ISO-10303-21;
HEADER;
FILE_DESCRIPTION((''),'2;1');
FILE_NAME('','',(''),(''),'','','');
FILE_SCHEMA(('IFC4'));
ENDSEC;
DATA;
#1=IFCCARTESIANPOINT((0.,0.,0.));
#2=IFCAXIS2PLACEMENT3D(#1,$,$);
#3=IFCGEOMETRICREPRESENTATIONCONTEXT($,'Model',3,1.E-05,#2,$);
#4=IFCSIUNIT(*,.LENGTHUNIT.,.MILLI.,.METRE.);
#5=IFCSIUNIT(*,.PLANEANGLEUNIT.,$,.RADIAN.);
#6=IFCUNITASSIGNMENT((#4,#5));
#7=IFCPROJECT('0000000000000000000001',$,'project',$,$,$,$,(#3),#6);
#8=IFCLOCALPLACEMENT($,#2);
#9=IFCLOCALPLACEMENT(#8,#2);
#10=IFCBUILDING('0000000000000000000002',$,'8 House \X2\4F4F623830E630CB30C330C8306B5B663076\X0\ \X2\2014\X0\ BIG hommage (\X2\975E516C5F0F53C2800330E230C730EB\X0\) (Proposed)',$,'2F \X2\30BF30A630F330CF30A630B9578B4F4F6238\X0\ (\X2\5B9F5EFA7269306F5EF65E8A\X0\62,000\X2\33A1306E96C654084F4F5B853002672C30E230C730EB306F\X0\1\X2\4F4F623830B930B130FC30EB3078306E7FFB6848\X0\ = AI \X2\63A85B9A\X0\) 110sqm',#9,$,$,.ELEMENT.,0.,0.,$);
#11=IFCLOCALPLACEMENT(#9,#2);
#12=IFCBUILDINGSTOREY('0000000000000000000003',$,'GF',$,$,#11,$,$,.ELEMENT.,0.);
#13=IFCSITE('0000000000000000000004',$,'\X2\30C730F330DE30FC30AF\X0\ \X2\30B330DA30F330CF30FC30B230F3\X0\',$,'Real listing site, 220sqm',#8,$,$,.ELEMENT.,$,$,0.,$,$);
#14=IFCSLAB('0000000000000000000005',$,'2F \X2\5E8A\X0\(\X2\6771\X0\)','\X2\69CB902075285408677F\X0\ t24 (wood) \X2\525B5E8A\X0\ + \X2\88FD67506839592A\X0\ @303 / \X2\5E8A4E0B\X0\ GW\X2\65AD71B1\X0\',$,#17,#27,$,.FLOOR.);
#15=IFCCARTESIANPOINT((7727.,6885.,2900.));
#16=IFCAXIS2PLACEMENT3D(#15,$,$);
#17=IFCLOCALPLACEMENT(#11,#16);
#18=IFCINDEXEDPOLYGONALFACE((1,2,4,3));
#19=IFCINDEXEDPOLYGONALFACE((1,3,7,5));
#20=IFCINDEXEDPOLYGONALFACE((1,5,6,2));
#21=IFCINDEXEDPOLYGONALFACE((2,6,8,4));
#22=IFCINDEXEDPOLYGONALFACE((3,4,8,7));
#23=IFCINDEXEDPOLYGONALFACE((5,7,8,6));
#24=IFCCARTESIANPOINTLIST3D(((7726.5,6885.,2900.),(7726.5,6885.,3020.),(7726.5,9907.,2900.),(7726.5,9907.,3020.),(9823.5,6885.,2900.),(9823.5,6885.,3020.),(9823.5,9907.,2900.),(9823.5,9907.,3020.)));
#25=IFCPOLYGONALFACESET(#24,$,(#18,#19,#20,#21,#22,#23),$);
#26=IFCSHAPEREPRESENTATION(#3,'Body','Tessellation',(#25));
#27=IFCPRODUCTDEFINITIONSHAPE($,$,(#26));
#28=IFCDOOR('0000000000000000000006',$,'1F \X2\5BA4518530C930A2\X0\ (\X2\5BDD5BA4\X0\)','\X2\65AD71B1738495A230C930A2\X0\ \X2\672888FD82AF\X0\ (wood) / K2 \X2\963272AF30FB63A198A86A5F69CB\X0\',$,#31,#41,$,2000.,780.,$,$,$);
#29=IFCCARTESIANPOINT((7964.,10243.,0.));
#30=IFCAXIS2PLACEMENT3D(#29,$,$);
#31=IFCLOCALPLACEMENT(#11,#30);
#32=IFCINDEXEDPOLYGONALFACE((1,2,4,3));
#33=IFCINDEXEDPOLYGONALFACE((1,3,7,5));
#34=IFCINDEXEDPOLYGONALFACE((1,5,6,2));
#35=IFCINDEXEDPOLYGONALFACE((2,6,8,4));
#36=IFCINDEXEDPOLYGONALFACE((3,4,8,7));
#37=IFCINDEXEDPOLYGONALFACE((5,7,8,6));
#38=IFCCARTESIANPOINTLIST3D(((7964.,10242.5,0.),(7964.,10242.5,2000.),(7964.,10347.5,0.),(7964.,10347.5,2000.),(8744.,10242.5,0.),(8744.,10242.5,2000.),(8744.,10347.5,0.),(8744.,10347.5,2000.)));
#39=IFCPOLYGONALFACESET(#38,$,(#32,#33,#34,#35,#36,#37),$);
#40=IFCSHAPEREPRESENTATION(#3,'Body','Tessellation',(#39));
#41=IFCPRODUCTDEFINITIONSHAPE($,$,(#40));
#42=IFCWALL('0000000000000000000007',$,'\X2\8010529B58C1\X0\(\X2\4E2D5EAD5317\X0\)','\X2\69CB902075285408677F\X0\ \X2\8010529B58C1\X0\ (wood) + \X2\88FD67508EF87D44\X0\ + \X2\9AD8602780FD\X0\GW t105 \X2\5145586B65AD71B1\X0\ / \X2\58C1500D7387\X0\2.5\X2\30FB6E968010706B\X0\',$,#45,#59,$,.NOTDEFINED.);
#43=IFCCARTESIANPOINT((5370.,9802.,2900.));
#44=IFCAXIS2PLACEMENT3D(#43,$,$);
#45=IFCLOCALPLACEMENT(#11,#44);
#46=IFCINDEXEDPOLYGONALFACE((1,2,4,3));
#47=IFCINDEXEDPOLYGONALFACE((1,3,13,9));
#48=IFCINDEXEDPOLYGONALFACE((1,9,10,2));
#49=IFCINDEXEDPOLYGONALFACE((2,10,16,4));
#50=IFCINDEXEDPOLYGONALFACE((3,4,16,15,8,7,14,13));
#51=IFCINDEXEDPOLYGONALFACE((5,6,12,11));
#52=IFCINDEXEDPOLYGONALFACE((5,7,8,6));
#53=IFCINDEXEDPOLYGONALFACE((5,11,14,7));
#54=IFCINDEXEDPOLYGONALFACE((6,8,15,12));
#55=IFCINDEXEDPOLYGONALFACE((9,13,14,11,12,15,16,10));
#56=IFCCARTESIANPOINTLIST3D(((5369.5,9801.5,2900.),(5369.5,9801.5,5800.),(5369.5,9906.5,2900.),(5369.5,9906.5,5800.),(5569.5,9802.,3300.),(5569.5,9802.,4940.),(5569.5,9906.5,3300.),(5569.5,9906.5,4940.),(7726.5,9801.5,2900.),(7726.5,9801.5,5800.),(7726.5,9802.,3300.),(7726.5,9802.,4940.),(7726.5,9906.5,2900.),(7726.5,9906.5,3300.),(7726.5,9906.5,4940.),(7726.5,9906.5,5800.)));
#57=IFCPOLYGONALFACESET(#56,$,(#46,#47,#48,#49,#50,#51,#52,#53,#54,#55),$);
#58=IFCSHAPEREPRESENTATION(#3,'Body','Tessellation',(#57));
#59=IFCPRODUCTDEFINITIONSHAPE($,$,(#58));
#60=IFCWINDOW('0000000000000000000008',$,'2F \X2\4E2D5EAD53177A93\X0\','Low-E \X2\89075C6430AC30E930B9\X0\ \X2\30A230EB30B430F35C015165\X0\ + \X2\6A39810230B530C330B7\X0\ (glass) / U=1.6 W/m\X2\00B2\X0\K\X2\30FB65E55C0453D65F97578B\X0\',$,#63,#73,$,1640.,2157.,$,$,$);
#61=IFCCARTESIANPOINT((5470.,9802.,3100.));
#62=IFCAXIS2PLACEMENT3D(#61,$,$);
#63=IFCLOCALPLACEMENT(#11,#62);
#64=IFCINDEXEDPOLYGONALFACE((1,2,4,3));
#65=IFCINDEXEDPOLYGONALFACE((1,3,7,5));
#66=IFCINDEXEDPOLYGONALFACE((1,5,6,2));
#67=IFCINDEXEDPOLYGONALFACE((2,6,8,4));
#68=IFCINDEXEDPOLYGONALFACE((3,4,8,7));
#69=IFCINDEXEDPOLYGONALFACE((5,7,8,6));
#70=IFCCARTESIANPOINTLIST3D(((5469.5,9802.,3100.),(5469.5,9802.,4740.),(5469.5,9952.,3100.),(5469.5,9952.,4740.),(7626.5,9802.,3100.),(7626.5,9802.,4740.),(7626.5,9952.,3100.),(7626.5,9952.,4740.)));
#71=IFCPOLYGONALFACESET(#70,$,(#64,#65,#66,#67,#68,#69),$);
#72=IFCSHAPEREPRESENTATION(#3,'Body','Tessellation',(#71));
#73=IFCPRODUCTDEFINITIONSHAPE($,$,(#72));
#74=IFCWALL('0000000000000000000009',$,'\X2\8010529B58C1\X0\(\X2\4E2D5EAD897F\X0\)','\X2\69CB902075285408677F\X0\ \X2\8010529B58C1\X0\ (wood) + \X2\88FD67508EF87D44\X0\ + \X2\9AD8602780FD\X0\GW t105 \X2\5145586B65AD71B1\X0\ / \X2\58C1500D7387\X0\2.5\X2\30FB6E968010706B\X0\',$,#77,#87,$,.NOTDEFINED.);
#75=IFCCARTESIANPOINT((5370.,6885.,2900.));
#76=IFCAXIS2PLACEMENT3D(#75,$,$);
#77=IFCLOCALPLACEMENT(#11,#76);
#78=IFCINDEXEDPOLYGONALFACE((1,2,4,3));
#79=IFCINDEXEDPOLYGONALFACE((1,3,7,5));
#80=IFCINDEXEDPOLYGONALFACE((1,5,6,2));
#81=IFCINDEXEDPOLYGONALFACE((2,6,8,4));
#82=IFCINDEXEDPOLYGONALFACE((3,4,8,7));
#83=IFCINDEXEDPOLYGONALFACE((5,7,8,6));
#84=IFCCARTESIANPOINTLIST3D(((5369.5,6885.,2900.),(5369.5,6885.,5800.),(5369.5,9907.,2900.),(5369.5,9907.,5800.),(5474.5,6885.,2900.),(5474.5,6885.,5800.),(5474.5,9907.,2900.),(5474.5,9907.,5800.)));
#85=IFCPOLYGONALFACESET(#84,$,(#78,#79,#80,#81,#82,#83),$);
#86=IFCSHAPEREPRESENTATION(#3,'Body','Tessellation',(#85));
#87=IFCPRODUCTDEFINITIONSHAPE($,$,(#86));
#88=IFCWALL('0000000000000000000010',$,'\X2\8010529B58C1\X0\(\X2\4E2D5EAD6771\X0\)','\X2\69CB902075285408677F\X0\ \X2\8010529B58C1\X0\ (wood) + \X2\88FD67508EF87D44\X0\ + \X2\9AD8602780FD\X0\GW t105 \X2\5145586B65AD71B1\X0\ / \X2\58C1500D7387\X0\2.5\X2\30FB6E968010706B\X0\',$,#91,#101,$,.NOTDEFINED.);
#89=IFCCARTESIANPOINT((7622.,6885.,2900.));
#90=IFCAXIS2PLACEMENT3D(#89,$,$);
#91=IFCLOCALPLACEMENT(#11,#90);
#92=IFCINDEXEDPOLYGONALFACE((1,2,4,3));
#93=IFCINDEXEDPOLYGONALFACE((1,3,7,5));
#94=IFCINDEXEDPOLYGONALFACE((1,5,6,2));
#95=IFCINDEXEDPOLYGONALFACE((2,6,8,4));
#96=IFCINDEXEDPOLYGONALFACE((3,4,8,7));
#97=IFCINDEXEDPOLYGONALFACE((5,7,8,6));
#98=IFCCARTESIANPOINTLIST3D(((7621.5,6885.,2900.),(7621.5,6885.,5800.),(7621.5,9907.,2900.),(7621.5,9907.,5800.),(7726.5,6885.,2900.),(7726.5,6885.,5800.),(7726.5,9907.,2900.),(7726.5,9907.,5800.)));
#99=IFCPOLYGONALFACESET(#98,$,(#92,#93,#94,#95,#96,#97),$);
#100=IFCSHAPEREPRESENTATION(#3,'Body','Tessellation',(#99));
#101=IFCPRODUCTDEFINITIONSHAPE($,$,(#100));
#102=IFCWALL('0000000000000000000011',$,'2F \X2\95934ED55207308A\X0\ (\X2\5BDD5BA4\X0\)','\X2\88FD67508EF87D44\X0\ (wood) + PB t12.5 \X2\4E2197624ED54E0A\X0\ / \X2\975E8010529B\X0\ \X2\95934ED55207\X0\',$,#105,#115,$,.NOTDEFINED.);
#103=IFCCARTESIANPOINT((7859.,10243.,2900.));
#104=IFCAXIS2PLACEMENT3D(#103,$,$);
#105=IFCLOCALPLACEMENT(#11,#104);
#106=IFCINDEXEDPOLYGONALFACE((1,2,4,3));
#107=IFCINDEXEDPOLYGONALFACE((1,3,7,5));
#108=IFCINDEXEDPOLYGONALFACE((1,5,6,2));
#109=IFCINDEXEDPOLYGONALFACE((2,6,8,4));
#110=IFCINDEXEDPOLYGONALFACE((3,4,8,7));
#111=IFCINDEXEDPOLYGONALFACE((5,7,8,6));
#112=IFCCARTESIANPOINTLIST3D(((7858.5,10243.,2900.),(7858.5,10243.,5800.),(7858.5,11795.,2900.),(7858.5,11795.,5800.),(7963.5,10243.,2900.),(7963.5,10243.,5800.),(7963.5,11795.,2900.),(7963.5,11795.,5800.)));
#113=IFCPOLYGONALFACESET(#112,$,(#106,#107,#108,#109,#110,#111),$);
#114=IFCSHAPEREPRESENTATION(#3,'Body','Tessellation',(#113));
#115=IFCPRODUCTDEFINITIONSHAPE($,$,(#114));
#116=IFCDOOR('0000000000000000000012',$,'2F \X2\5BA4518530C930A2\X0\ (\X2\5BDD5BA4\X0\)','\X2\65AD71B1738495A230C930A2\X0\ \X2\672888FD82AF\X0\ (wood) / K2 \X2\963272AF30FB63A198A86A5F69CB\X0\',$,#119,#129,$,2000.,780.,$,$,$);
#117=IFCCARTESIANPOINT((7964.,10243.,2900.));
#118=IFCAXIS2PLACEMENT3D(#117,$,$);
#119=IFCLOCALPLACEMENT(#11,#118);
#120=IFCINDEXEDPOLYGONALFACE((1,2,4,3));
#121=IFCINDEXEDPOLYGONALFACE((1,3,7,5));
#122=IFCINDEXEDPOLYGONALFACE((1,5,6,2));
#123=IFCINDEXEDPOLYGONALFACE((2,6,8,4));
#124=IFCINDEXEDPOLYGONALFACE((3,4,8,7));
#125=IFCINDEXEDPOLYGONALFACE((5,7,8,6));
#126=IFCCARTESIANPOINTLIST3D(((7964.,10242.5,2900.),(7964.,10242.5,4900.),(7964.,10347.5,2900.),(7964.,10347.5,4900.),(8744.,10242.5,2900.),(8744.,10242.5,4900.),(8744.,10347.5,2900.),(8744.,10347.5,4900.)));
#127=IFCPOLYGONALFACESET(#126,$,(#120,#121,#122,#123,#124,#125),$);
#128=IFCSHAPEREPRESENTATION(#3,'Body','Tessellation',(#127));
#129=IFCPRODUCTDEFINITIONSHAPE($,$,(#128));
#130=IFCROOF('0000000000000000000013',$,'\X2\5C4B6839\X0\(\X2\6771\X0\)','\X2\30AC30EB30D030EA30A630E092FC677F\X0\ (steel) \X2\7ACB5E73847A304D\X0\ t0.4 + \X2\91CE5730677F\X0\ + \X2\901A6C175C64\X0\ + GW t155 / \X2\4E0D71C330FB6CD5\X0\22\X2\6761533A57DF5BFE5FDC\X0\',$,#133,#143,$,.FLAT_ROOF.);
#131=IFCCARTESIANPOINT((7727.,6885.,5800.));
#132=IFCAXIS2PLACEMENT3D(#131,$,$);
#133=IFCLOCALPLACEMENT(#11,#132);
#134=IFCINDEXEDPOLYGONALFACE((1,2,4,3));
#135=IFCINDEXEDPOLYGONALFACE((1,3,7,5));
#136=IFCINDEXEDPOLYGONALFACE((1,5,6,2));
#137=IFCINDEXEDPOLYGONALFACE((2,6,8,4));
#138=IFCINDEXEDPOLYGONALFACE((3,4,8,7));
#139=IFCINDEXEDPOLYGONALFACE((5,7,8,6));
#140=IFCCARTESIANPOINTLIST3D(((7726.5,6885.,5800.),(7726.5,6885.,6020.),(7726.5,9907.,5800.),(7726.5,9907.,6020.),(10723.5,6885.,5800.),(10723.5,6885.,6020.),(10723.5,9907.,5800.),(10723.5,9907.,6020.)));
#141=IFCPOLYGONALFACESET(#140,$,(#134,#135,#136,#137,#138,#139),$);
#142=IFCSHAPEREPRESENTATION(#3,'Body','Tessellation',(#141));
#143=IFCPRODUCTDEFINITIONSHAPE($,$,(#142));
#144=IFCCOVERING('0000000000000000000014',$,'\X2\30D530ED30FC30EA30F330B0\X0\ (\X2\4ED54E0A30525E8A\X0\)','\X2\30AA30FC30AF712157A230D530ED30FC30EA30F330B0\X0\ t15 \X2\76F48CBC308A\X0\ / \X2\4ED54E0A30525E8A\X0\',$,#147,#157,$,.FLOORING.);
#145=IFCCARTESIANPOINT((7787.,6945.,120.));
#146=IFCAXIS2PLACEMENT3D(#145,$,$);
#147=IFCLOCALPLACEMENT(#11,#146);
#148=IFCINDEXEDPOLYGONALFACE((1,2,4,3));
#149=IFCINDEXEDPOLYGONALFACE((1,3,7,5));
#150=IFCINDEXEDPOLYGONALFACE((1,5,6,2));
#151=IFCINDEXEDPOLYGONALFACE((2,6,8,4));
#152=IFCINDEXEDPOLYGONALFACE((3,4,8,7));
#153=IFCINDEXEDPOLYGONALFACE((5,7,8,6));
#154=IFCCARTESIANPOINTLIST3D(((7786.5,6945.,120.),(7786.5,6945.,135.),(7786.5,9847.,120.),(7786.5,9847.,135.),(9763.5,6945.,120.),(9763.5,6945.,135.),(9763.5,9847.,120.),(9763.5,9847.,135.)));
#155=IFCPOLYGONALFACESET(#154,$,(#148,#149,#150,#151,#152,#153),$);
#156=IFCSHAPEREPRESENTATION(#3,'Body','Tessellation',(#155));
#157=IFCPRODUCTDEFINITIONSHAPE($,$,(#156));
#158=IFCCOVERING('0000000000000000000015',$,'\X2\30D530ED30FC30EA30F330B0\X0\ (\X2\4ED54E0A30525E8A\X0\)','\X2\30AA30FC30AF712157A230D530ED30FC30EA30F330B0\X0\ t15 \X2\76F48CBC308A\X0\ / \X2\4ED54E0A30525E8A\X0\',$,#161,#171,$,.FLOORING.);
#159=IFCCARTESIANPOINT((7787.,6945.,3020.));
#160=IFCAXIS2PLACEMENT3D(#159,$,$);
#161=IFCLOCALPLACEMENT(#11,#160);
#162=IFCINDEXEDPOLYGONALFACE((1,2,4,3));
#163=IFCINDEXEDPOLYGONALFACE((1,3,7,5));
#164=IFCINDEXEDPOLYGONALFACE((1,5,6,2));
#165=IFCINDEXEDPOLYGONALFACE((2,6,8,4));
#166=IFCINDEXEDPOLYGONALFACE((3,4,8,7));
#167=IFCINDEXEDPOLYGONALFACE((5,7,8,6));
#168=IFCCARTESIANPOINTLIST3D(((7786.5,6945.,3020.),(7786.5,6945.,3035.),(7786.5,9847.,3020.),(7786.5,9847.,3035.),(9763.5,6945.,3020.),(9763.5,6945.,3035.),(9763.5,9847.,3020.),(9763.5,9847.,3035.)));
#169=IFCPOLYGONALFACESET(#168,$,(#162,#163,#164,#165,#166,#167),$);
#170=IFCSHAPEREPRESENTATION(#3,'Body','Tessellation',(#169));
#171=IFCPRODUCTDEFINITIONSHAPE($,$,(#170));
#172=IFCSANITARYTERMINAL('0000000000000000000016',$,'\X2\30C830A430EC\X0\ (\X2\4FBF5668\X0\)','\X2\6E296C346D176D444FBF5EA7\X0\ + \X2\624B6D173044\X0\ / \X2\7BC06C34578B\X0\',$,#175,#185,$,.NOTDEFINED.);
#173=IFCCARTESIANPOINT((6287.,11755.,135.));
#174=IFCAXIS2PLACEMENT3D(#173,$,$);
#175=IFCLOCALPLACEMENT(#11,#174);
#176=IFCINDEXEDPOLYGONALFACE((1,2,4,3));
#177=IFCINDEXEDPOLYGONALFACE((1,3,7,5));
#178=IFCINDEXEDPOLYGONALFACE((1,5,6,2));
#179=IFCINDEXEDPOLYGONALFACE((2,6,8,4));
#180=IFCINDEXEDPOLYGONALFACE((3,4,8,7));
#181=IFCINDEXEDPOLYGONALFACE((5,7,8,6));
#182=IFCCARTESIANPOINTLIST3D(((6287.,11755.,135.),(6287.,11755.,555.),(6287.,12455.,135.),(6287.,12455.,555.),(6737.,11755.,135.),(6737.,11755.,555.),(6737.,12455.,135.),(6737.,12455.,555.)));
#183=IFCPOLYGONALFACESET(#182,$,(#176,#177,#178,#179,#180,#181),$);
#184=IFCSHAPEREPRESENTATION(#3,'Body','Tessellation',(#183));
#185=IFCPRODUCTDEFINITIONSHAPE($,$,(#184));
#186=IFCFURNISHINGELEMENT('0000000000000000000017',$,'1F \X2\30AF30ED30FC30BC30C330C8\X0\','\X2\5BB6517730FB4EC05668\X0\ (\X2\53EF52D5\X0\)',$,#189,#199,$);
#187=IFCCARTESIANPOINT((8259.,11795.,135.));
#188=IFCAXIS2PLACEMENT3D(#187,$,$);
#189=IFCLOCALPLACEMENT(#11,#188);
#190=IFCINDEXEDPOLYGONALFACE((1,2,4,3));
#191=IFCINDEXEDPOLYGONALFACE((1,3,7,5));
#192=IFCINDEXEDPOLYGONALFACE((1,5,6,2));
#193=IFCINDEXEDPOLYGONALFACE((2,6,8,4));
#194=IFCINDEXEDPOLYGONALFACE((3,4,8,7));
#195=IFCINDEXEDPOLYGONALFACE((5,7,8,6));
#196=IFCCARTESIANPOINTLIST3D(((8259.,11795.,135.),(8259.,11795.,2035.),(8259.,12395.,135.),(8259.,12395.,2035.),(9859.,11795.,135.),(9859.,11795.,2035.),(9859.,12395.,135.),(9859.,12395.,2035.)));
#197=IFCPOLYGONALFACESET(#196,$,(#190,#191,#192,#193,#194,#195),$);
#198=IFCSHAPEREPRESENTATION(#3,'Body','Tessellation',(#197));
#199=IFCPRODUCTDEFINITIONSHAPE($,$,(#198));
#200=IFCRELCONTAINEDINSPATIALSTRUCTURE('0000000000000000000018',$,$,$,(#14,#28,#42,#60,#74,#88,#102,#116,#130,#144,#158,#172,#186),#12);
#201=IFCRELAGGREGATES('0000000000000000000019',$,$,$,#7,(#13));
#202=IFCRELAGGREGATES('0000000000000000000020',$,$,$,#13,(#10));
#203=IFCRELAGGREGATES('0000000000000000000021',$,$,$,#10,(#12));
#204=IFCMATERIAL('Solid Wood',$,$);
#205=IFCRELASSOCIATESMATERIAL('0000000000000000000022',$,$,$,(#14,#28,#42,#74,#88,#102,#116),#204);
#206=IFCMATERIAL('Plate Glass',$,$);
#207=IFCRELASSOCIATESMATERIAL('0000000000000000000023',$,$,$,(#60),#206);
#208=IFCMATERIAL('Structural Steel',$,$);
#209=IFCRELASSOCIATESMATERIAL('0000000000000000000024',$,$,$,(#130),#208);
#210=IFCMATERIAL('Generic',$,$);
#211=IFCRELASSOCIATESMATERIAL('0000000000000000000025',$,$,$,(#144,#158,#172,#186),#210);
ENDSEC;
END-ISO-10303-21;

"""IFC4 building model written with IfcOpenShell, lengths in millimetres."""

from ifc_helpers import new_model, si_unit, frame, frame_2d, origin, place, context, project, spatial, rectangle, extrude, material, element, fill, save


model = new_model("IFC4")

# Units and contexts
model_context = context("Model", 3, precision=1e-05, world=origin())
ifc_project = project(units=[si_unit("LENGTHUNIT", "METRE", prefix="MILLI"), si_unit("PLANEANGLEUNIT", "RADIAN")], contexts=[model_context])

# Site, building, storey
site_placement = place(None, origin())
site = spatial("IfcSite", under=ifc_project, at=site_placement, Name="デンマーク コペンハーゲン", ObjectType="Real listing site, 220sqm", CompositionType="ELEMENT", RefElevation=0.0)
building_placement = place(site_placement, origin())
building = spatial("IfcBuilding", under=site, at=building_placement, Name="8 House 住戸ユニットに学ぶ — BIG hommage (非公式参考モデル) (Proposed)", ObjectType="2F タウンハウス型住戸 (実建物は延床62,000㎡の集合住宅。本モデルは1住戸スケールへの翻案 = AI 推定) 110sqm", CompositionType="ELEMENT", ElevationOfRefHeight=0.0, ElevationOfTerrain=0.0)
storey_placement = place(building_placement, origin())
storey = spatial("IfcBuildingStorey", under=building, at=storey_placement, Name="GF", CompositionType="ELEMENT", Elevation=0.0)

# Slab
ifc_material_1 = material(Name="Solid Wood")
slab_1_placement = place(storey_placement, frame((7727.0, 6885.0, 2900.0)))
element("IfcSlab", 1, at=slab_1_placement, inside=storey, material=ifc_material_1, Name="2F 床(東)", Description="構造用合板 t24 (wood) 剛床 + 製材根太 @303 / 床下 GW断熱", PredefinedType="FLOOR", context=model_context, shape_type="SweptSolid", body=[
    extrude(rectangle(XDim=2097.0, YDim=3022.0, at=frame_2d((1048.0, 1511.0))), frame((7727.0, 6885.0, 2900.0)), (0.0, 0.0, 1.0), 120.0),
])

# Shared definitions
ifc_material_2 = material(Name="Plate Glass")

# Door
door_1_placement = place(storey_placement, frame((7964.0, 10243.0, 0.0)))
element("IfcDoor", 2, at=door_1_placement, inside=storey, material=ifc_material_1, Name="1F 室内ドア (寝室)", Description="断熱玄関ドア 木製芯 (wood) / K2 防犯・採風機構", OverallHeight=2000.0, OverallWidth=780.0, context=model_context, shape_type="SweptSolid", body=[
    extrude(rectangle(XDim=780.0, YDim=105.0, at=frame_2d((390.0, 52.0))), frame((7964.0, 10243.0, 0.0)), (0.0, 0.0, 1.0), 2000.0),
])

# Wall, opening, window
wall_1_placement = place(storey_placement, frame((5370.0, 9802.0, 2900.0)))
wall_1 = element("IfcWall", 3, at=wall_1_placement, inside=storey, material=ifc_material_1, Name="耐力壁(中庭北)", Description="構造用合板 耐力壁 (wood) + 製材軸組 + 高性能GW t105 充填断熱 / 壁倍率2.5・準耐火", PredefinedType="NOTDEFINED", context=model_context, shape_type="SweptSolid", body=[
    extrude(rectangle(XDim=2357.0, YDim=105.0, at=frame_2d((1178.0, 52.0))), frame((5370.0, 9802.0, 2900.0)), (0.0, 0.0, 1.0), 2900.0),
])
opening_1_placement = place(storey_placement, frame((5470.0, 9802.0, 3100.0)))
opening_1 = element("IfcOpeningElement", 4, at=opening_1_placement, cuts=wall_1, PredefinedType="NOTDEFINED", context=model_context, shape_type="SweptSolid", body=[
    extrude(rectangle(XDim=2157.0, YDim=150.0, at=frame_2d((1078.0, 75.0))), frame((5470.0, 9802.0, 3100.0)), (0.0, 0.0, 1.0), 1640.0),
])
window_1_placement = place(storey_placement, frame((5470.0, 9802.0, 3100.0)))
window_1 = element("IfcWindow", 5, at=window_1_placement, inside=storey, material=ifc_material_2, Name="2F 中庭北窓", Description="Low-E 複層ガラス アルゴン封入 + 樹脂サッシ (glass) / U=1.6 W/m²K・日射取得型", OverallHeight=1640.0, OverallWidth=2157.0, context=model_context, shape_type="SweptSolid", body=[
    extrude(rectangle(XDim=2157.0, YDim=150.0, at=frame_2d((1078.0, 75.0))), frame((5470.0, 9802.0, 3100.0)), (0.0, 0.0, 1.0), 1640.0),
])
fill(opening_1, window_1)

# Walls
wall_2_placement = place(storey_placement, frame((5370.0, 6885.0, 2900.0)))
element("IfcWall", 6, at=wall_2_placement, inside=storey, material=ifc_material_1, Name="耐力壁(中庭西)", Description="構造用合板 耐力壁 (wood) + 製材軸組 + 高性能GW t105 充填断熱 / 壁倍率2.5・準耐火", PredefinedType="NOTDEFINED", context=model_context, shape_type="SweptSolid", body=[
    extrude(rectangle(XDim=105.0, YDim=3022.0, at=frame_2d((52.0, 1511.0))), frame((5370.0, 6885.0, 2900.0)), (0.0, 0.0, 1.0), 2900.0),
])
wall_3_placement = place(storey_placement, frame((7622.0, 6885.0, 2900.0)))
element("IfcWall", 7, at=wall_3_placement, inside=storey, material=ifc_material_1, Name="耐力壁(中庭東)", Description="構造用合板 耐力壁 (wood) + 製材軸組 + 高性能GW t105 充填断熱 / 壁倍率2.5・準耐火", PredefinedType="NOTDEFINED", context=model_context, shape_type="SweptSolid", body=[
    extrude(rectangle(XDim=105.0, YDim=3022.0, at=frame_2d((52.0, 1511.0))), frame((7622.0, 6885.0, 2900.0)), (0.0, 0.0, 1.0), 2900.0),
])
wall_4_placement = place(storey_placement, frame((7859.0, 10243.0, 2900.0)))
element("IfcWall", 8, at=wall_4_placement, inside=storey, material=ifc_material_1, Name="2F 間仕切り (寝室)", Description="製材軸組 (wood) + PB t12.5 両面仕上 / 非耐力 間仕切", PredefinedType="NOTDEFINED", context=model_context, shape_type="SweptSolid", body=[
    extrude(rectangle(XDim=105.0, YDim=1552.0, at=frame_2d((52.0, 776.0))), frame((7859.0, 10243.0, 2900.0)), (0.0, 0.0, 1.0), 2900.0),
])

# Door
door_2_placement = place(storey_placement, frame((7964.0, 10243.0, 2900.0)))
element("IfcDoor", 9, at=door_2_placement, inside=storey, material=ifc_material_1, Name="2F 室内ドア (寝室)", Description="断熱玄関ドア 木製芯 (wood) / K2 防犯・採風機構", OverallHeight=2000.0, OverallWidth=780.0, context=model_context, shape_type="SweptSolid", body=[
    extrude(rectangle(XDim=780.0, YDim=105.0, at=frame_2d((390.0, 52.0))), frame((7964.0, 10243.0, 2900.0)), (0.0, 0.0, 1.0), 2000.0),
])

# Roof
ifc_material_3 = material(Name="Structural Steel")
roof_placement = place(storey_placement, frame((7727.0, 6885.0, 5800.0)))
element("IfcRoof", 10, at=roof_placement, inside=storey, material=ifc_material_3, Name="屋根(東)", Description="ガルバリウム鋼板 (steel) 立平葺き t0.4 + 野地板 + 通気層 + GW t155 / 不燃・法22条区域対応", PredefinedType="FLAT_ROOF", context=model_context, shape_type="SweptSolid", body=[
    extrude(rectangle(XDim=2997.0, YDim=3022.0, at=frame_2d((1498.0, 1511.0))), frame((7727.0, 6885.0, 5800.0)), (0.0, 0.0, 1.0), 220.0),
])

# Coverings
ifc_material_4 = material(Name="Generic")
covering_1_placement = place(storey_placement, frame((7787.0, 6945.0, 120.0)))
element("IfcCovering", 11, at=covering_1_placement, inside=storey, material=ifc_material_4, Name="フローリング (仕上げ床)", Description="オーク無垢フローリング t15 直貼り / 仕上げ床", PredefinedType="FLOORING", context=model_context, shape_type="SweptSolid", body=[
    extrude(rectangle(XDim=1977.0, YDim=2902.0, at=frame_2d((988.0, 1451.0))), frame((7787.0, 6945.0, 120.0)), (0.0, 0.0, 1.0), 15.0),
])
covering_2_placement = place(storey_placement, frame((7787.0, 6945.0, 3020.0)))
element("IfcCovering", 12, at=covering_2_placement, inside=storey, material=ifc_material_4, Name="フローリング (仕上げ床)", Description="オーク無垢フローリング t15 直貼り / 仕上げ床", PredefinedType="FLOORING", context=model_context, shape_type="SweptSolid", body=[
    extrude(rectangle(XDim=1977.0, YDim=2902.0, at=frame_2d((988.0, 1451.0))), frame((7787.0, 6945.0, 3020.0)), (0.0, 0.0, 1.0), 15.0),
])

# Sanitary terminal
sanitary_terminal_placement = place(storey_placement, frame((6287.0, 11755.0, 135.0)))
element("IfcSanitaryTerminal", 13, at=sanitary_terminal_placement, inside=storey, material=ifc_material_4, Name="トイレ (便器)", Description="温水洗浄便座 + 手洗い / 節水型", PredefinedType="NOTDEFINED", context=model_context, shape_type="SweptSolid", body=[
    extrude(rectangle(XDim=450.0, YDim=700.0, at=frame_2d((225.0, 350.0))), frame((6287.0, 11755.0, 135.0)), (0.0, 0.0, 1.0), 420.0),
])

# Furnishing element
furnishing_1_placement = place(storey_placement, frame((8259.0, 11795.0, 135.0)))
element("IfcFurnishingElement", 14, at=furnishing_1_placement, inside=storey, material=ifc_material_4, Name="1F クローゼット", Description="家具・什器 (可動)", context=model_context, shape_type="SweptSolid", body=[
    extrude(rectangle(XDim=1600.0, YDim=600.0, at=frame_2d((800.0, 300.0))), frame((8259.0, 11795.0, 135.0)), (0.0, 0.0, 1.0), 1900.0),
])

save(model, "model.ifc")
